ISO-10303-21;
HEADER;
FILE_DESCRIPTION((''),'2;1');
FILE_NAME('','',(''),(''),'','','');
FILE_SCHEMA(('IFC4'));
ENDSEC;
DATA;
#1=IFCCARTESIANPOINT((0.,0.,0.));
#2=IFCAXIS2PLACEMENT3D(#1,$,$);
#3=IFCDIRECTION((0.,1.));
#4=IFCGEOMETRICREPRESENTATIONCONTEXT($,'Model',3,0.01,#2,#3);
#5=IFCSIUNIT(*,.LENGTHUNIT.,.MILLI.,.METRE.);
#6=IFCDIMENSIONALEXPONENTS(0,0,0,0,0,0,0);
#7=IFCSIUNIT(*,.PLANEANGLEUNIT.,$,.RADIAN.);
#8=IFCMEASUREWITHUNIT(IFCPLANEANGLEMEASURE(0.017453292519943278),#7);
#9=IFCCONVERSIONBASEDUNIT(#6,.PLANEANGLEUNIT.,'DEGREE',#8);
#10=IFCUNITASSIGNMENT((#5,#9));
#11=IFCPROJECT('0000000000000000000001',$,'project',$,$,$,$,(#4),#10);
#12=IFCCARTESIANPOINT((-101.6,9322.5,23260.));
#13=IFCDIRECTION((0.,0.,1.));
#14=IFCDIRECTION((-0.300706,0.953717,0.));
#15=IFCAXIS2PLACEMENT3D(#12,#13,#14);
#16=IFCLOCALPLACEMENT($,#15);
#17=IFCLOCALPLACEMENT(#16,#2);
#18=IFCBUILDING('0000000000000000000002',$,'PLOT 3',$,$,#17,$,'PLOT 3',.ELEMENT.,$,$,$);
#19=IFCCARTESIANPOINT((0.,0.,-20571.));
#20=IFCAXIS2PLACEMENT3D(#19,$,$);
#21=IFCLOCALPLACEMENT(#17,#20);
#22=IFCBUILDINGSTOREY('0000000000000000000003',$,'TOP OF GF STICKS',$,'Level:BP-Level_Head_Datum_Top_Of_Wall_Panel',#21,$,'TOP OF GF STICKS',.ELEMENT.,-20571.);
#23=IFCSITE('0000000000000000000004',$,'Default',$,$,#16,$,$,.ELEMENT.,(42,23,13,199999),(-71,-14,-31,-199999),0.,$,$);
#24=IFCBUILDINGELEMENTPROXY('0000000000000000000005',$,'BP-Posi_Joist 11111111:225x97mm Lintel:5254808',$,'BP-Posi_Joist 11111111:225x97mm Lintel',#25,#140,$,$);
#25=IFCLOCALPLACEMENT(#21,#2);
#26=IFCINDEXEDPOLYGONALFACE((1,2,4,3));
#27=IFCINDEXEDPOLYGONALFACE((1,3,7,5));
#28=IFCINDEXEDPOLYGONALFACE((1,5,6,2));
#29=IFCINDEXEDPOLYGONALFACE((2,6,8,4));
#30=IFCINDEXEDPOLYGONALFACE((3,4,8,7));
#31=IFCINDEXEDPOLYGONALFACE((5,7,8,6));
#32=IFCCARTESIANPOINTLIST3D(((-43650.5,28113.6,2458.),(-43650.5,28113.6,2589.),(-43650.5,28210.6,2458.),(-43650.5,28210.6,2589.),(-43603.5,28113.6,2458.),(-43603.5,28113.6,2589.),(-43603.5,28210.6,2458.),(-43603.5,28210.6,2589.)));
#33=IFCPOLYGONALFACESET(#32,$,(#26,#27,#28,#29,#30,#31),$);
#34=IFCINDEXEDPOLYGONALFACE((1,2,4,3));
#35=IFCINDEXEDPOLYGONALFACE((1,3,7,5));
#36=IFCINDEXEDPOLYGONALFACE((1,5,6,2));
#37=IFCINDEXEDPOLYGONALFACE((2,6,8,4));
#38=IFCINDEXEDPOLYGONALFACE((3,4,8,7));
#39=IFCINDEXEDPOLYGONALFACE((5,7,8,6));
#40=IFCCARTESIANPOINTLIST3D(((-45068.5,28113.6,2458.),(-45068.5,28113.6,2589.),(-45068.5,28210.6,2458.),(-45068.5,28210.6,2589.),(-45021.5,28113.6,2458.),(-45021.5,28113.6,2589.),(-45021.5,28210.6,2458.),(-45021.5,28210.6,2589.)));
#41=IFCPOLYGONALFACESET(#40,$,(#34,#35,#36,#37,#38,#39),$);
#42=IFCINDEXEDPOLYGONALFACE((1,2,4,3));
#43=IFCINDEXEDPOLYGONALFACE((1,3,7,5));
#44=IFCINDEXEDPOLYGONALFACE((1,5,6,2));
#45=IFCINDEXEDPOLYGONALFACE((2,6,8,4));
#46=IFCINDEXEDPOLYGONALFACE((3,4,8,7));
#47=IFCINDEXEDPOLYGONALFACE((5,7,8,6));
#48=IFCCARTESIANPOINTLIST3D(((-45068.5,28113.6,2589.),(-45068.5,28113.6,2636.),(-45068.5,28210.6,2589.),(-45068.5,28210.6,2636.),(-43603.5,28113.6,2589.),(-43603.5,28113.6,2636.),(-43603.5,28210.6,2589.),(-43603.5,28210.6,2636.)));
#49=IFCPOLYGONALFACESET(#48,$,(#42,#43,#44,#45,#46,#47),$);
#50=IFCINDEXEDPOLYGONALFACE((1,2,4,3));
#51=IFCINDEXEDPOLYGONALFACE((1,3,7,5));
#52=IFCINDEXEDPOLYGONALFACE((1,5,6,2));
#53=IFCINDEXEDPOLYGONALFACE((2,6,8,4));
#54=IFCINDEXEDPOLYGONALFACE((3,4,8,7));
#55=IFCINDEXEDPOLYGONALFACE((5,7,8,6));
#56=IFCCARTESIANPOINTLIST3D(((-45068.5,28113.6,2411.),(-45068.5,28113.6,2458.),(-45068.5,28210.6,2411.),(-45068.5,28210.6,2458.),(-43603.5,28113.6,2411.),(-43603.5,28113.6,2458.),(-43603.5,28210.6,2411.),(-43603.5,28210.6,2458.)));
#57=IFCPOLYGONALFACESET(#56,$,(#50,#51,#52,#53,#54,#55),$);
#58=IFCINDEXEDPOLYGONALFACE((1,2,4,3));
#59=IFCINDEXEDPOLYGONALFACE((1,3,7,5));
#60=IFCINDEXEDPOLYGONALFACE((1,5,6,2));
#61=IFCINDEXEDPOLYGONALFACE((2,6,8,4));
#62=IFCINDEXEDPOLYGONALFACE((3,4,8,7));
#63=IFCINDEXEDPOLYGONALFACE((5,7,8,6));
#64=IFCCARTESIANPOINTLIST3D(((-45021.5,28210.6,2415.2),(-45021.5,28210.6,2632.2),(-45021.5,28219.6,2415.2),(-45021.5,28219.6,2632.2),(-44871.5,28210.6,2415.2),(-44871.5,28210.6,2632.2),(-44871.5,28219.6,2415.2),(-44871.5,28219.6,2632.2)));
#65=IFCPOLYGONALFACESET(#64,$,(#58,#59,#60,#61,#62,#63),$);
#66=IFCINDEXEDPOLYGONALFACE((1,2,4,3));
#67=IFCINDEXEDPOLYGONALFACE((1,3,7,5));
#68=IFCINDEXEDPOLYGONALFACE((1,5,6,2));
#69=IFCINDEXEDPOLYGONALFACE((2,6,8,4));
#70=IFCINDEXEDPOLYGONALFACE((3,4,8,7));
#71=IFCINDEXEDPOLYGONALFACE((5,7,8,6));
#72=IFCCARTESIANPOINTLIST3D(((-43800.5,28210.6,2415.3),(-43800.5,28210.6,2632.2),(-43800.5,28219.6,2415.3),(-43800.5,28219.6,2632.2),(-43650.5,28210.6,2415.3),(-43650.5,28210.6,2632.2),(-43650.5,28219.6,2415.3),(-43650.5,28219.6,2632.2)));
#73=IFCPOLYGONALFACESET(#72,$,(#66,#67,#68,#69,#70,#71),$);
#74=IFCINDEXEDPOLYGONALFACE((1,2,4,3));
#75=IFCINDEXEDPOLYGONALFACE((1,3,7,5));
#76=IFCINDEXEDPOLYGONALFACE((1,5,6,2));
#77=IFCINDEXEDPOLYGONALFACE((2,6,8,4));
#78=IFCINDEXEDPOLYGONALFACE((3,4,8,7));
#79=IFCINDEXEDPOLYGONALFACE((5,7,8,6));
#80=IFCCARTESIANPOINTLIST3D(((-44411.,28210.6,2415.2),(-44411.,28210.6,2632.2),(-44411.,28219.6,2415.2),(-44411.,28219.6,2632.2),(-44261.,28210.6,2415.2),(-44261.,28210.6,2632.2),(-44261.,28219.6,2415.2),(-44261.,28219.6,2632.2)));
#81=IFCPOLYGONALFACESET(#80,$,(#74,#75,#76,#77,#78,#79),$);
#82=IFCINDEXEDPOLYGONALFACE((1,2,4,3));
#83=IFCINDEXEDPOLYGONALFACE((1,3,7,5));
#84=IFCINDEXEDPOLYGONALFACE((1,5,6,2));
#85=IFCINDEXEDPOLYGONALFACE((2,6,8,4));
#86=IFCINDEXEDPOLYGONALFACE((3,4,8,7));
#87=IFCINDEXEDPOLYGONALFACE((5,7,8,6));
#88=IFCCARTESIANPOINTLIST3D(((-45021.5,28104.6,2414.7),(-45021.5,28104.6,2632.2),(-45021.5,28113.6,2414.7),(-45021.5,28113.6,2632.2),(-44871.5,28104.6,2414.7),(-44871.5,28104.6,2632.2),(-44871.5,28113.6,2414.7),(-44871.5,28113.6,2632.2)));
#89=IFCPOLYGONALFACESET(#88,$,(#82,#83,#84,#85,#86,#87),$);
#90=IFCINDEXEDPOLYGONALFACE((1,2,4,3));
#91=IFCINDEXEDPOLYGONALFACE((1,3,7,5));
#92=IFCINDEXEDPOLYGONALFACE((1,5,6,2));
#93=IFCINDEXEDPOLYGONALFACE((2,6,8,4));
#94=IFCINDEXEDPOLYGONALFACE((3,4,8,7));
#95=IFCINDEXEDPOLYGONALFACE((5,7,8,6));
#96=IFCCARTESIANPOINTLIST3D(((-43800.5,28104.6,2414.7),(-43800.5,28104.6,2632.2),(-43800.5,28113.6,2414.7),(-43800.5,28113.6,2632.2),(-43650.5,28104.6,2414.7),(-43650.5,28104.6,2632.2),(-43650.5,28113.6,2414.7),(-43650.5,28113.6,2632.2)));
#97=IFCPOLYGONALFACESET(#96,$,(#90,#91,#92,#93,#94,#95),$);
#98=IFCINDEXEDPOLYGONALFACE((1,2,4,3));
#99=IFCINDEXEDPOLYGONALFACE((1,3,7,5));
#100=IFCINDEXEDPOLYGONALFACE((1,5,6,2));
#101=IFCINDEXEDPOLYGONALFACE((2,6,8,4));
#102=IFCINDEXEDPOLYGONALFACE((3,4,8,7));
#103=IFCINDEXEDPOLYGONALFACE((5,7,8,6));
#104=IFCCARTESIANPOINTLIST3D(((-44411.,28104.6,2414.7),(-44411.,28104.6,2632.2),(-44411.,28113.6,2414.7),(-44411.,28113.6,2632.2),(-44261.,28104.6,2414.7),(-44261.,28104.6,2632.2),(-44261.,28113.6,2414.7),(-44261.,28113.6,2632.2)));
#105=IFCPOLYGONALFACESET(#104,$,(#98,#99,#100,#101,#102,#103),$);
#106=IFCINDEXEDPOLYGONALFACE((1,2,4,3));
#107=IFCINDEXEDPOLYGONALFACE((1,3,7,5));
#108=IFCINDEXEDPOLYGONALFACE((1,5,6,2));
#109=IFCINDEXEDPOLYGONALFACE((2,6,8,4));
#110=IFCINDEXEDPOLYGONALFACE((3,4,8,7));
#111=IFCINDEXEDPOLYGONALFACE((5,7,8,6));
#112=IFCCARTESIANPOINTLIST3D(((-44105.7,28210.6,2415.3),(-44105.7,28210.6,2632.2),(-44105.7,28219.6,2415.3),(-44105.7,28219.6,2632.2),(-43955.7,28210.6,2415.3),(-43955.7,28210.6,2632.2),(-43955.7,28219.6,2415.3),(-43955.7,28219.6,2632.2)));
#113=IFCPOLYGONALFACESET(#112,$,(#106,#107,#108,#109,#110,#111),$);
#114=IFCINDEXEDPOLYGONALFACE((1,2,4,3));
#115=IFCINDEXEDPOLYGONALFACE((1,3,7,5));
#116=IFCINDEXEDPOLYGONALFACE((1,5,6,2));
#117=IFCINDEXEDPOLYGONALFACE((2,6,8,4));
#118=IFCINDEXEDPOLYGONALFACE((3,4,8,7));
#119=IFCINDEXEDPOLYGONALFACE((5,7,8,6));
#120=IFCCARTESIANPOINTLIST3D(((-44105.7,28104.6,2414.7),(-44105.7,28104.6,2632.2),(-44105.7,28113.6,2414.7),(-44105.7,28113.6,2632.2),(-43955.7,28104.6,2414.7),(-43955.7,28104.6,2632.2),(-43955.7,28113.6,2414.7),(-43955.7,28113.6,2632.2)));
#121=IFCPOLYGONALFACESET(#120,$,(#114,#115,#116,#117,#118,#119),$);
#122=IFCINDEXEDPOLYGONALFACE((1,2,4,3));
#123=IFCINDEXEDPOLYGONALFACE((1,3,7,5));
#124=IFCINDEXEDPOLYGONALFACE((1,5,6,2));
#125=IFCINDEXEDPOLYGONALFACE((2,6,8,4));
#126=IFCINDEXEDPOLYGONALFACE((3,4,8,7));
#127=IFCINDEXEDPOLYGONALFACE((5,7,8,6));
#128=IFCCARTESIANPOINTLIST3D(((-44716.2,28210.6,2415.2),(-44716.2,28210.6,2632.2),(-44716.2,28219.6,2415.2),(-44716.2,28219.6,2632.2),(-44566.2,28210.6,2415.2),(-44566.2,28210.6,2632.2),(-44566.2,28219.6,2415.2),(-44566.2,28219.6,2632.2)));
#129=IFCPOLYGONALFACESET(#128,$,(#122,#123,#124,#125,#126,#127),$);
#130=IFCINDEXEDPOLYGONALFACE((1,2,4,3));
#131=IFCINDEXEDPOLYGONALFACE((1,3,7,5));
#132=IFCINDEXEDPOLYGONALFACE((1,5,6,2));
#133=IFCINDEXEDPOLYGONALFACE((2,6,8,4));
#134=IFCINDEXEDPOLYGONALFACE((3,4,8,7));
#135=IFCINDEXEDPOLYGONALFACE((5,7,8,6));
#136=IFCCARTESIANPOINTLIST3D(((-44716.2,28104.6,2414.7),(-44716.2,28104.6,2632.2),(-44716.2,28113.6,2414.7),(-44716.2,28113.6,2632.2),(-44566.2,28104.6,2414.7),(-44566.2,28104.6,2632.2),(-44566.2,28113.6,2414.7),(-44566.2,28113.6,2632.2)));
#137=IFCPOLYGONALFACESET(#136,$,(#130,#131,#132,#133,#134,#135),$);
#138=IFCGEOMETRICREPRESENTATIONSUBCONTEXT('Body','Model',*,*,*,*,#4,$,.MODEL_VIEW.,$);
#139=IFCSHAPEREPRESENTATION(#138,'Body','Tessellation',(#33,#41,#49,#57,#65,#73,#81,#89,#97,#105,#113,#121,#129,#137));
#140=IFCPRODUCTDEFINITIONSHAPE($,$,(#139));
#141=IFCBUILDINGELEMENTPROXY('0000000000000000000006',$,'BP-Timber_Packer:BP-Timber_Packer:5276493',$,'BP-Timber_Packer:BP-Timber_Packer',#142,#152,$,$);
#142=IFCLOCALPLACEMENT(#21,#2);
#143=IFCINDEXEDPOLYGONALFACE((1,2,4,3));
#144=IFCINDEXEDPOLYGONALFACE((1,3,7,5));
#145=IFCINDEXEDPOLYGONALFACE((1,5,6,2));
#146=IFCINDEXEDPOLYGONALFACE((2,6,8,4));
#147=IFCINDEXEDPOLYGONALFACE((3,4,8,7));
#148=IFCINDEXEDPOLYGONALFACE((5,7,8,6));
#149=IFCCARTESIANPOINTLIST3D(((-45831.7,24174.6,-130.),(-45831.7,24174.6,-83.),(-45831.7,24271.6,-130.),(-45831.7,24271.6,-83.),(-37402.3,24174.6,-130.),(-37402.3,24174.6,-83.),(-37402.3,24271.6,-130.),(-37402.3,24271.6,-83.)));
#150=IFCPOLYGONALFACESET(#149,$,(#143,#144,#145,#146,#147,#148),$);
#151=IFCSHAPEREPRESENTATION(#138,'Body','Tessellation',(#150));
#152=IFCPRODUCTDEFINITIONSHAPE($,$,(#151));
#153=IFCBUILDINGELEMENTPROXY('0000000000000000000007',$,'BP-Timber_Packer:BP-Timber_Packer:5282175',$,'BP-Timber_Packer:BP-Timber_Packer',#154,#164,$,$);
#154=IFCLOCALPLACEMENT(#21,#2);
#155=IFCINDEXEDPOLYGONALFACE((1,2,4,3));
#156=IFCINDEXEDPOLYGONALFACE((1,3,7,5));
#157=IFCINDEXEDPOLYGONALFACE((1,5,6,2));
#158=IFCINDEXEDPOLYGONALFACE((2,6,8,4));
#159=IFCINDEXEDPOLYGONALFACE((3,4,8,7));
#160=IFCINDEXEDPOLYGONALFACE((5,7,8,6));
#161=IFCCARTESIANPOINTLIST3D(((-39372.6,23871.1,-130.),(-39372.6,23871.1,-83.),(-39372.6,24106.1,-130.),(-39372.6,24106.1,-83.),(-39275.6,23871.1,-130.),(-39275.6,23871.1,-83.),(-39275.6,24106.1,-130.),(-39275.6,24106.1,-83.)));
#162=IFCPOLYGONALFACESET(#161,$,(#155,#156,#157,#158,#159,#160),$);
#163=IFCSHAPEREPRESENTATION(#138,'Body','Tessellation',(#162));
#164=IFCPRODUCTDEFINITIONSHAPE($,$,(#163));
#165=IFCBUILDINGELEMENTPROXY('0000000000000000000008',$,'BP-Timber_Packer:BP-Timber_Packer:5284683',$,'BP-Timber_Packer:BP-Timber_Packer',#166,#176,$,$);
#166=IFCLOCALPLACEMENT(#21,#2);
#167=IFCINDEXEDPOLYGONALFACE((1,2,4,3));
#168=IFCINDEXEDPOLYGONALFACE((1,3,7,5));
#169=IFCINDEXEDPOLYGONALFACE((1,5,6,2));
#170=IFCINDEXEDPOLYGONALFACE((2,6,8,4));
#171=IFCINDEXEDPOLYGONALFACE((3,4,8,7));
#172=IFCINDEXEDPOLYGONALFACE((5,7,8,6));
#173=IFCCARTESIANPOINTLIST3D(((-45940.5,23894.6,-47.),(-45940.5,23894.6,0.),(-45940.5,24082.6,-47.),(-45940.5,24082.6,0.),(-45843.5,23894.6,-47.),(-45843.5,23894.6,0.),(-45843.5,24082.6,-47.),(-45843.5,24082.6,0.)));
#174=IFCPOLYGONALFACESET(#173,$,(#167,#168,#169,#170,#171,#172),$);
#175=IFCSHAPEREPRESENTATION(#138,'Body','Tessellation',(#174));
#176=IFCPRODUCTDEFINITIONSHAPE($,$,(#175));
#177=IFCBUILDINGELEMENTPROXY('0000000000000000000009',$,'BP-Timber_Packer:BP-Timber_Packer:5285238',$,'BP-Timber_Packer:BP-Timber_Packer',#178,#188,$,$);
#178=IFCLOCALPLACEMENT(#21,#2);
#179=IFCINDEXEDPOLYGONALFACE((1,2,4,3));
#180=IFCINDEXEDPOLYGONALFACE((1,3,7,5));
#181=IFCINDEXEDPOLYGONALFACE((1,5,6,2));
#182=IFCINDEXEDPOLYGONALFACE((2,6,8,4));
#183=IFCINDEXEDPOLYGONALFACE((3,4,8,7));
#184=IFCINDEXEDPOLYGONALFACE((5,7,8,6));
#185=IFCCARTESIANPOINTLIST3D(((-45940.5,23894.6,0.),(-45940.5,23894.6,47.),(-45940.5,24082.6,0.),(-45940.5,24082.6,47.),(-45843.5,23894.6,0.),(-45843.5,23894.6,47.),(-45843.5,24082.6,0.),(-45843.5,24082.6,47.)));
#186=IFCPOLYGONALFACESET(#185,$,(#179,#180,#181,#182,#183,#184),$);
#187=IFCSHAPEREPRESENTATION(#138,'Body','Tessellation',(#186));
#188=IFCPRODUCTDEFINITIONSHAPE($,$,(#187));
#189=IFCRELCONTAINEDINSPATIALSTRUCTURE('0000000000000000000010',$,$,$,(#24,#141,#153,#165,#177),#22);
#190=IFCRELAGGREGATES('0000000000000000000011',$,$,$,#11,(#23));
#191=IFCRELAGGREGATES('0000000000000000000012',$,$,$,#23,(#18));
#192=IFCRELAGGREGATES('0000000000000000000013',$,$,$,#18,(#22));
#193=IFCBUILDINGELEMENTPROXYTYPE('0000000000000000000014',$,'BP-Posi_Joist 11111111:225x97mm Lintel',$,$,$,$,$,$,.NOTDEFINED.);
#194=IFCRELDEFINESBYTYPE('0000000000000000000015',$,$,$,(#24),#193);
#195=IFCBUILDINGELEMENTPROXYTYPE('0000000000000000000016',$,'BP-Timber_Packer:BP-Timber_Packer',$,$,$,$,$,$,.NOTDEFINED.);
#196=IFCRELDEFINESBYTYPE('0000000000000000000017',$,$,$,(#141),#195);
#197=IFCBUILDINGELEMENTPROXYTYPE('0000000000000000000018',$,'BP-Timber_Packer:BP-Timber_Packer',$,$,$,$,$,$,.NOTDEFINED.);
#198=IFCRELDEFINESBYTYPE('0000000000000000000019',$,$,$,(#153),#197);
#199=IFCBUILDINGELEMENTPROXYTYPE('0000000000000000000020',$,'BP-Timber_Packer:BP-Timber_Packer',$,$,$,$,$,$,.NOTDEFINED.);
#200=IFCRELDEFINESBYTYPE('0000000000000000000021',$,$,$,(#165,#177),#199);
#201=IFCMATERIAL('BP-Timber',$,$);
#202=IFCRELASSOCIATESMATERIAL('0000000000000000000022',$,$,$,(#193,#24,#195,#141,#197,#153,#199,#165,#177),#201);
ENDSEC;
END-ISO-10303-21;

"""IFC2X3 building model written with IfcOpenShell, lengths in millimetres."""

from ifc_helpers import new_model, entity, si_unit, converted_unit, direction, frame, frame_2d, origin, origin_2d_with_axis, place, context, subcontext, project, spatial, rectangle, extrude, source, transform, mapped, material, type_object, type_shapes, element, save


model = new_model("IFC2X3")

# Units and contexts
model_context = context("Model", 3, precision=0.01, world=origin(), true_north=direction((0.0, 1.0)))
body_context = subcontext(model_context, "Body", "Model", "MODEL_VIEW")
ifc_project = project(units=[si_unit("LENGTHUNIT", "METRE", prefix="MILLI"), converted_unit("PLANEANGLEUNIT", "DEGREE", entity("IfcPlaneAngleMeasure", 0.017453292519943278), si_unit("PLANEANGLEUNIT", "RADIAN"), dimensions=[0, 0, 0, 0, 0, 0, 0])], contexts=[model_context])

# Site, building, storey
site_placement = place(None, frame((-101.6, 9322.5, 23260.0), z_axis=(0.0, 0.0, 1.0), x_axis=(-0.300706, 0.953717, 0.0)))
site = spatial("IfcSite", under=ifc_project, at=site_placement, Name="Default", CompositionType="ELEMENT", RefLatitude=(42, 23, 13, 199999), RefLongitude=(-71, -14, -31, -199999), RefElevation=0.0)
building_placement = place(site_placement, origin())
building = spatial("IfcBuilding", under=site, at=building_placement, Name="PLOT 3", LongName="PLOT 3", CompositionType="ELEMENT")
storey_placement = place(building_placement, frame((0.0, 0.0, -20571.0)))
storey = spatial("IfcBuildingStorey", under=building, at=storey_placement, Name="TOP OF GF STICKS", ObjectType="Level:BP-Level_Head_Datum_Top_Of_Wall_Panel", LongName="TOP OF GF STICKS", CompositionType="ELEMENT", Elevation=-20571.0)

# Building element proxies
ifc_material_1 = material(Name="BP-Timber")
building_element_proxy_type_1 = type_object("IfcBuildingElementProxyType", Name="BP-Posi_Joist 11111111:225x97mm Lintel", PredefinedType="NOTDEFINED", material=ifc_material_1)
shared_shape_1 = source(origin(), body_context, "Body", "SweptSolid", [
    extrude(rectangle(XDim=97.0, YDim=47.0, at=origin_2d_with_axis()), frame((320.4, 0.0, -178.0), z_axis=(0.0, 0.0, 1.0), x_axis=(0.0, 1.0, 0.0)), (0.0, 0.0, 1.0), 131.0),
    extrude(rectangle(XDim=97.0, YDim=47.0, at=origin_2d_with_axis()), frame((1738.4, 0.0, -178.0), z_axis=(0.0, 0.0, 1.0), x_axis=(0.0, 1.0, 0.0)), (0.0, 0.0, 1.0), 131.0),
    extrude(rectangle(XDim=1465.0, YDim=97.0, at=frame_2d((0.0, 0.0), x_axis=(1.0, 0.0))), frame((1029.4, 0.0, -47.0)), (0.0, 0.0, 1.0), 47.0),
    extrude(rectangle(XDim=1465.0, YDim=97.0, at=frame_2d((0.0, 0.0), x_axis=(1.0, 0.0))), frame((1029.4, 0.0, -225.0)), (0.0, 0.0, 1.0), 47.0),
    extrude(rectangle(XDim=150.0, YDim=9.0, at=frame_2d((0.0, 0.0), x_axis=(1.0, 0.0))), frame((1639.9, -53.0, -220.8)), (0.0, 0.0, 1.0), 217.0),
    extrude(rectangle(XDim=150.0, YDim=9.0, at=frame_2d((0.0, 0.0), x_axis=(1.0, 0.0))), frame((418.9, -53.0, -220.7), z_axis=(0.0, 0.0, 1.0), x_axis=(-1.0, 0.0, 0.0)), (0.0, 0.0, 1.0), 217.0),
    extrude(rectangle(XDim=150.0, YDim=9.0, at=frame_2d((0.0, 0.0), x_axis=(1.0, 0.0))), frame((1029.4, -53.0, -220.8)), (0.0, 0.0, 1.0), 217.0),
    extrude(rectangle(XDim=150.0, YDim=9.0, at=origin_2d_with_axis()), frame((1639.9, 53.0, -221.3)), (0.0, 0.0, 1.0), 217.5),
    extrude(rectangle(XDim=150.0, YDim=9.0, at=frame_2d((0.0, 0.0), x_axis=(1.0, 0.0))), frame((418.9, 53.0, -221.3), z_axis=(0.0, 0.0, 1.0), x_axis=(-1.0, 0.0, 0.0)), (0.0, 0.0, 1.0), 217.5),
    extrude(rectangle(XDim=150.0, YDim=9.0, at=origin_2d_with_axis()), frame((1029.4, 53.0, -221.3)), (0.0, 0.0, 1.0), 217.5),
    extrude(rectangle(XDim=150.0, YDim=9.0, at=frame_2d((0.0, 0.0), x_axis=(1.0, 0.0))), frame((724.2, -53.0, -220.7), z_axis=(0.0, 0.0, 1.0), x_axis=(-1.0, 0.0, 0.0)), (0.0, 0.0, 1.0), 217.0),
    extrude(rectangle(XDim=150.0, YDim=9.0, at=frame_2d((0.0, 0.0), x_axis=(1.0, 0.0))), frame((724.2, 53.0, -221.3), z_axis=(0.0, 0.0, 1.0), x_axis=(-1.0, 0.0, 0.0)), (0.0, 0.0, 1.0), 217.5),
    extrude(rectangle(XDim=150.0, YDim=9.0, at=origin_2d_with_axis()), frame((1334.7, -53.0, -220.8)), (0.0, 0.0, 1.0), 217.0),
    extrude(rectangle(XDim=150.0, YDim=9.0, at=origin_2d_with_axis()), frame((1334.7, 53.0, -221.3)), (0.0, 0.0, 1.0), 217.5),
])
type_shapes(building_element_proxy_type_1, [shared_shape_1])
proxy_1_placement = place(storey_placement, frame((-43306.6, 28162.1, 2636.0), z_axis=(0.0, 0.0, 1.0), x_axis=(-1.0, 0.0, 0.0)))
element("IfcBuildingElementProxy", 1, at=proxy_1_placement, inside=storey, type_object=building_element_proxy_type_1, material=ifc_material_1, Name="BP-Posi_Joist 11111111:225x97mm Lintel:5254808", ObjectType="BP-Posi_Joist 11111111:225x97mm Lintel", context=body_context, shape_type="MappedRepresentation", body=[
    mapped(shared_shape_1, transform((0.0, 0.0, 0.0), scale=1.0)),
])
building_element_proxy_type_2 = type_object("IfcBuildingElementProxyType", Name="BP-Timber_Packer:BP-Timber_Packer", PredefinedType="NOTDEFINED", material=ifc_material_1)
shared_shape_2 = source(origin(), body_context, "Body", "SweptSolid", [
    extrude(rectangle(XDim=8429.4, YDim=97.0, at=origin_2d_with_axis()), frame((0.0, 0.0, 0.0), z_axis=(0.0, 0.0, 1.0), x_axis=(-1.0, 0.0, 0.0)), (0.0, 0.0, 1.0), 47.0),
])
type_shapes(building_element_proxy_type_2, [shared_shape_2])
proxy_2_placement = place(storey_placement, frame((-41617.0, 24223.1, -130.0)))
element("IfcBuildingElementProxy", 2, at=proxy_2_placement, inside=storey, type_object=building_element_proxy_type_2, material=ifc_material_1, Name="BP-Timber_Packer:BP-Timber_Packer:5276493", ObjectType="BP-Timber_Packer:BP-Timber_Packer", context=body_context, shape_type="MappedRepresentation", body=[
    mapped(shared_shape_2, transform((0.0, 0.0, 0.0), scale=1.0)),
])
building_element_proxy_type_3 = type_object("IfcBuildingElementProxyType", Name="BP-Timber_Packer:BP-Timber_Packer", PredefinedType="NOTDEFINED", material=ifc_material_1)
shared_shape_3 = source(origin(), body_context, "Body", "SweptSolid", [
    extrude(rectangle(XDim=235.0, YDim=97.0, at=origin_2d_with_axis()), frame((0.0, 0.0, 0.0), z_axis=(0.0, 0.0, 1.0), x_axis=(-1.0, 0.0, 0.0)), (0.0, 0.0, 1.0), 47.0),
])
type_shapes(building_element_proxy_type_3, [shared_shape_3])
proxy_3_placement = place(storey_placement, frame((-39324.1, 23988.6, -130.0), z_axis=(0.0, 0.0, 1.0), x_axis=(0.0, -1.0, 0.0)))
element("IfcBuildingElementProxy", 3, at=proxy_3_placement, inside=storey, type_object=building_element_proxy_type_3, material=ifc_material_1, Name="BP-Timber_Packer:BP-Timber_Packer:5282175", ObjectType="BP-Timber_Packer:BP-Timber_Packer", context=body_context, shape_type="MappedRepresentation", body=[
    mapped(shared_shape_3, transform((0.0, 0.0, 0.0), scale=1.0)),
])
building_element_proxy_type_4 = type_object("IfcBuildingElementProxyType", Name="BP-Timber_Packer:BP-Timber_Packer", PredefinedType="NOTDEFINED", material=ifc_material_1)
shared_shape_4 = source(origin(), body_context, "Body", "SweptSolid", [
    extrude(rectangle(XDim=97.0, YDim=188.0, at=origin_2d_with_axis()), frame((0.0, 0.0, 0.0), z_axis=(0.0, 0.0, 1.0), x_axis=(0.0, 1.0, 0.0)), (0.0, 0.0, 1.0), 47.0),
])
type_shapes(building_element_proxy_type_4, [shared_shape_4])
for number, where, z_axis, x_axis, name in (
    (4, (-45892.0, 23988.6, -47.0), (0.0, 0.0, 1.0), (0.0, 1.0, 0.0), "BP-Timber_Packer:BP-Timber_Packer:5284683"),
    (5, (-45892.0, 23988.6, 0.0), (0.0, 0.0, 1.0), (0.0, 1.0, 0.0), "BP-Timber_Packer:BP-Timber_Packer:5285238"),
):
    element("IfcBuildingElementProxy", number, at=place(storey_placement, frame(where, z_axis=z_axis, x_axis=x_axis)), inside=storey, type_object=building_element_proxy_type_4, material=ifc_material_1, Name=name, ObjectType="BP-Timber_Packer:BP-Timber_Packer", context=body_context, shape_type="MappedRepresentation", body=[
        mapped(shared_shape_4, transform((0.0, 0.0, 0.0), scale=1.0)),
    ])

save(model, "model.ifc")
